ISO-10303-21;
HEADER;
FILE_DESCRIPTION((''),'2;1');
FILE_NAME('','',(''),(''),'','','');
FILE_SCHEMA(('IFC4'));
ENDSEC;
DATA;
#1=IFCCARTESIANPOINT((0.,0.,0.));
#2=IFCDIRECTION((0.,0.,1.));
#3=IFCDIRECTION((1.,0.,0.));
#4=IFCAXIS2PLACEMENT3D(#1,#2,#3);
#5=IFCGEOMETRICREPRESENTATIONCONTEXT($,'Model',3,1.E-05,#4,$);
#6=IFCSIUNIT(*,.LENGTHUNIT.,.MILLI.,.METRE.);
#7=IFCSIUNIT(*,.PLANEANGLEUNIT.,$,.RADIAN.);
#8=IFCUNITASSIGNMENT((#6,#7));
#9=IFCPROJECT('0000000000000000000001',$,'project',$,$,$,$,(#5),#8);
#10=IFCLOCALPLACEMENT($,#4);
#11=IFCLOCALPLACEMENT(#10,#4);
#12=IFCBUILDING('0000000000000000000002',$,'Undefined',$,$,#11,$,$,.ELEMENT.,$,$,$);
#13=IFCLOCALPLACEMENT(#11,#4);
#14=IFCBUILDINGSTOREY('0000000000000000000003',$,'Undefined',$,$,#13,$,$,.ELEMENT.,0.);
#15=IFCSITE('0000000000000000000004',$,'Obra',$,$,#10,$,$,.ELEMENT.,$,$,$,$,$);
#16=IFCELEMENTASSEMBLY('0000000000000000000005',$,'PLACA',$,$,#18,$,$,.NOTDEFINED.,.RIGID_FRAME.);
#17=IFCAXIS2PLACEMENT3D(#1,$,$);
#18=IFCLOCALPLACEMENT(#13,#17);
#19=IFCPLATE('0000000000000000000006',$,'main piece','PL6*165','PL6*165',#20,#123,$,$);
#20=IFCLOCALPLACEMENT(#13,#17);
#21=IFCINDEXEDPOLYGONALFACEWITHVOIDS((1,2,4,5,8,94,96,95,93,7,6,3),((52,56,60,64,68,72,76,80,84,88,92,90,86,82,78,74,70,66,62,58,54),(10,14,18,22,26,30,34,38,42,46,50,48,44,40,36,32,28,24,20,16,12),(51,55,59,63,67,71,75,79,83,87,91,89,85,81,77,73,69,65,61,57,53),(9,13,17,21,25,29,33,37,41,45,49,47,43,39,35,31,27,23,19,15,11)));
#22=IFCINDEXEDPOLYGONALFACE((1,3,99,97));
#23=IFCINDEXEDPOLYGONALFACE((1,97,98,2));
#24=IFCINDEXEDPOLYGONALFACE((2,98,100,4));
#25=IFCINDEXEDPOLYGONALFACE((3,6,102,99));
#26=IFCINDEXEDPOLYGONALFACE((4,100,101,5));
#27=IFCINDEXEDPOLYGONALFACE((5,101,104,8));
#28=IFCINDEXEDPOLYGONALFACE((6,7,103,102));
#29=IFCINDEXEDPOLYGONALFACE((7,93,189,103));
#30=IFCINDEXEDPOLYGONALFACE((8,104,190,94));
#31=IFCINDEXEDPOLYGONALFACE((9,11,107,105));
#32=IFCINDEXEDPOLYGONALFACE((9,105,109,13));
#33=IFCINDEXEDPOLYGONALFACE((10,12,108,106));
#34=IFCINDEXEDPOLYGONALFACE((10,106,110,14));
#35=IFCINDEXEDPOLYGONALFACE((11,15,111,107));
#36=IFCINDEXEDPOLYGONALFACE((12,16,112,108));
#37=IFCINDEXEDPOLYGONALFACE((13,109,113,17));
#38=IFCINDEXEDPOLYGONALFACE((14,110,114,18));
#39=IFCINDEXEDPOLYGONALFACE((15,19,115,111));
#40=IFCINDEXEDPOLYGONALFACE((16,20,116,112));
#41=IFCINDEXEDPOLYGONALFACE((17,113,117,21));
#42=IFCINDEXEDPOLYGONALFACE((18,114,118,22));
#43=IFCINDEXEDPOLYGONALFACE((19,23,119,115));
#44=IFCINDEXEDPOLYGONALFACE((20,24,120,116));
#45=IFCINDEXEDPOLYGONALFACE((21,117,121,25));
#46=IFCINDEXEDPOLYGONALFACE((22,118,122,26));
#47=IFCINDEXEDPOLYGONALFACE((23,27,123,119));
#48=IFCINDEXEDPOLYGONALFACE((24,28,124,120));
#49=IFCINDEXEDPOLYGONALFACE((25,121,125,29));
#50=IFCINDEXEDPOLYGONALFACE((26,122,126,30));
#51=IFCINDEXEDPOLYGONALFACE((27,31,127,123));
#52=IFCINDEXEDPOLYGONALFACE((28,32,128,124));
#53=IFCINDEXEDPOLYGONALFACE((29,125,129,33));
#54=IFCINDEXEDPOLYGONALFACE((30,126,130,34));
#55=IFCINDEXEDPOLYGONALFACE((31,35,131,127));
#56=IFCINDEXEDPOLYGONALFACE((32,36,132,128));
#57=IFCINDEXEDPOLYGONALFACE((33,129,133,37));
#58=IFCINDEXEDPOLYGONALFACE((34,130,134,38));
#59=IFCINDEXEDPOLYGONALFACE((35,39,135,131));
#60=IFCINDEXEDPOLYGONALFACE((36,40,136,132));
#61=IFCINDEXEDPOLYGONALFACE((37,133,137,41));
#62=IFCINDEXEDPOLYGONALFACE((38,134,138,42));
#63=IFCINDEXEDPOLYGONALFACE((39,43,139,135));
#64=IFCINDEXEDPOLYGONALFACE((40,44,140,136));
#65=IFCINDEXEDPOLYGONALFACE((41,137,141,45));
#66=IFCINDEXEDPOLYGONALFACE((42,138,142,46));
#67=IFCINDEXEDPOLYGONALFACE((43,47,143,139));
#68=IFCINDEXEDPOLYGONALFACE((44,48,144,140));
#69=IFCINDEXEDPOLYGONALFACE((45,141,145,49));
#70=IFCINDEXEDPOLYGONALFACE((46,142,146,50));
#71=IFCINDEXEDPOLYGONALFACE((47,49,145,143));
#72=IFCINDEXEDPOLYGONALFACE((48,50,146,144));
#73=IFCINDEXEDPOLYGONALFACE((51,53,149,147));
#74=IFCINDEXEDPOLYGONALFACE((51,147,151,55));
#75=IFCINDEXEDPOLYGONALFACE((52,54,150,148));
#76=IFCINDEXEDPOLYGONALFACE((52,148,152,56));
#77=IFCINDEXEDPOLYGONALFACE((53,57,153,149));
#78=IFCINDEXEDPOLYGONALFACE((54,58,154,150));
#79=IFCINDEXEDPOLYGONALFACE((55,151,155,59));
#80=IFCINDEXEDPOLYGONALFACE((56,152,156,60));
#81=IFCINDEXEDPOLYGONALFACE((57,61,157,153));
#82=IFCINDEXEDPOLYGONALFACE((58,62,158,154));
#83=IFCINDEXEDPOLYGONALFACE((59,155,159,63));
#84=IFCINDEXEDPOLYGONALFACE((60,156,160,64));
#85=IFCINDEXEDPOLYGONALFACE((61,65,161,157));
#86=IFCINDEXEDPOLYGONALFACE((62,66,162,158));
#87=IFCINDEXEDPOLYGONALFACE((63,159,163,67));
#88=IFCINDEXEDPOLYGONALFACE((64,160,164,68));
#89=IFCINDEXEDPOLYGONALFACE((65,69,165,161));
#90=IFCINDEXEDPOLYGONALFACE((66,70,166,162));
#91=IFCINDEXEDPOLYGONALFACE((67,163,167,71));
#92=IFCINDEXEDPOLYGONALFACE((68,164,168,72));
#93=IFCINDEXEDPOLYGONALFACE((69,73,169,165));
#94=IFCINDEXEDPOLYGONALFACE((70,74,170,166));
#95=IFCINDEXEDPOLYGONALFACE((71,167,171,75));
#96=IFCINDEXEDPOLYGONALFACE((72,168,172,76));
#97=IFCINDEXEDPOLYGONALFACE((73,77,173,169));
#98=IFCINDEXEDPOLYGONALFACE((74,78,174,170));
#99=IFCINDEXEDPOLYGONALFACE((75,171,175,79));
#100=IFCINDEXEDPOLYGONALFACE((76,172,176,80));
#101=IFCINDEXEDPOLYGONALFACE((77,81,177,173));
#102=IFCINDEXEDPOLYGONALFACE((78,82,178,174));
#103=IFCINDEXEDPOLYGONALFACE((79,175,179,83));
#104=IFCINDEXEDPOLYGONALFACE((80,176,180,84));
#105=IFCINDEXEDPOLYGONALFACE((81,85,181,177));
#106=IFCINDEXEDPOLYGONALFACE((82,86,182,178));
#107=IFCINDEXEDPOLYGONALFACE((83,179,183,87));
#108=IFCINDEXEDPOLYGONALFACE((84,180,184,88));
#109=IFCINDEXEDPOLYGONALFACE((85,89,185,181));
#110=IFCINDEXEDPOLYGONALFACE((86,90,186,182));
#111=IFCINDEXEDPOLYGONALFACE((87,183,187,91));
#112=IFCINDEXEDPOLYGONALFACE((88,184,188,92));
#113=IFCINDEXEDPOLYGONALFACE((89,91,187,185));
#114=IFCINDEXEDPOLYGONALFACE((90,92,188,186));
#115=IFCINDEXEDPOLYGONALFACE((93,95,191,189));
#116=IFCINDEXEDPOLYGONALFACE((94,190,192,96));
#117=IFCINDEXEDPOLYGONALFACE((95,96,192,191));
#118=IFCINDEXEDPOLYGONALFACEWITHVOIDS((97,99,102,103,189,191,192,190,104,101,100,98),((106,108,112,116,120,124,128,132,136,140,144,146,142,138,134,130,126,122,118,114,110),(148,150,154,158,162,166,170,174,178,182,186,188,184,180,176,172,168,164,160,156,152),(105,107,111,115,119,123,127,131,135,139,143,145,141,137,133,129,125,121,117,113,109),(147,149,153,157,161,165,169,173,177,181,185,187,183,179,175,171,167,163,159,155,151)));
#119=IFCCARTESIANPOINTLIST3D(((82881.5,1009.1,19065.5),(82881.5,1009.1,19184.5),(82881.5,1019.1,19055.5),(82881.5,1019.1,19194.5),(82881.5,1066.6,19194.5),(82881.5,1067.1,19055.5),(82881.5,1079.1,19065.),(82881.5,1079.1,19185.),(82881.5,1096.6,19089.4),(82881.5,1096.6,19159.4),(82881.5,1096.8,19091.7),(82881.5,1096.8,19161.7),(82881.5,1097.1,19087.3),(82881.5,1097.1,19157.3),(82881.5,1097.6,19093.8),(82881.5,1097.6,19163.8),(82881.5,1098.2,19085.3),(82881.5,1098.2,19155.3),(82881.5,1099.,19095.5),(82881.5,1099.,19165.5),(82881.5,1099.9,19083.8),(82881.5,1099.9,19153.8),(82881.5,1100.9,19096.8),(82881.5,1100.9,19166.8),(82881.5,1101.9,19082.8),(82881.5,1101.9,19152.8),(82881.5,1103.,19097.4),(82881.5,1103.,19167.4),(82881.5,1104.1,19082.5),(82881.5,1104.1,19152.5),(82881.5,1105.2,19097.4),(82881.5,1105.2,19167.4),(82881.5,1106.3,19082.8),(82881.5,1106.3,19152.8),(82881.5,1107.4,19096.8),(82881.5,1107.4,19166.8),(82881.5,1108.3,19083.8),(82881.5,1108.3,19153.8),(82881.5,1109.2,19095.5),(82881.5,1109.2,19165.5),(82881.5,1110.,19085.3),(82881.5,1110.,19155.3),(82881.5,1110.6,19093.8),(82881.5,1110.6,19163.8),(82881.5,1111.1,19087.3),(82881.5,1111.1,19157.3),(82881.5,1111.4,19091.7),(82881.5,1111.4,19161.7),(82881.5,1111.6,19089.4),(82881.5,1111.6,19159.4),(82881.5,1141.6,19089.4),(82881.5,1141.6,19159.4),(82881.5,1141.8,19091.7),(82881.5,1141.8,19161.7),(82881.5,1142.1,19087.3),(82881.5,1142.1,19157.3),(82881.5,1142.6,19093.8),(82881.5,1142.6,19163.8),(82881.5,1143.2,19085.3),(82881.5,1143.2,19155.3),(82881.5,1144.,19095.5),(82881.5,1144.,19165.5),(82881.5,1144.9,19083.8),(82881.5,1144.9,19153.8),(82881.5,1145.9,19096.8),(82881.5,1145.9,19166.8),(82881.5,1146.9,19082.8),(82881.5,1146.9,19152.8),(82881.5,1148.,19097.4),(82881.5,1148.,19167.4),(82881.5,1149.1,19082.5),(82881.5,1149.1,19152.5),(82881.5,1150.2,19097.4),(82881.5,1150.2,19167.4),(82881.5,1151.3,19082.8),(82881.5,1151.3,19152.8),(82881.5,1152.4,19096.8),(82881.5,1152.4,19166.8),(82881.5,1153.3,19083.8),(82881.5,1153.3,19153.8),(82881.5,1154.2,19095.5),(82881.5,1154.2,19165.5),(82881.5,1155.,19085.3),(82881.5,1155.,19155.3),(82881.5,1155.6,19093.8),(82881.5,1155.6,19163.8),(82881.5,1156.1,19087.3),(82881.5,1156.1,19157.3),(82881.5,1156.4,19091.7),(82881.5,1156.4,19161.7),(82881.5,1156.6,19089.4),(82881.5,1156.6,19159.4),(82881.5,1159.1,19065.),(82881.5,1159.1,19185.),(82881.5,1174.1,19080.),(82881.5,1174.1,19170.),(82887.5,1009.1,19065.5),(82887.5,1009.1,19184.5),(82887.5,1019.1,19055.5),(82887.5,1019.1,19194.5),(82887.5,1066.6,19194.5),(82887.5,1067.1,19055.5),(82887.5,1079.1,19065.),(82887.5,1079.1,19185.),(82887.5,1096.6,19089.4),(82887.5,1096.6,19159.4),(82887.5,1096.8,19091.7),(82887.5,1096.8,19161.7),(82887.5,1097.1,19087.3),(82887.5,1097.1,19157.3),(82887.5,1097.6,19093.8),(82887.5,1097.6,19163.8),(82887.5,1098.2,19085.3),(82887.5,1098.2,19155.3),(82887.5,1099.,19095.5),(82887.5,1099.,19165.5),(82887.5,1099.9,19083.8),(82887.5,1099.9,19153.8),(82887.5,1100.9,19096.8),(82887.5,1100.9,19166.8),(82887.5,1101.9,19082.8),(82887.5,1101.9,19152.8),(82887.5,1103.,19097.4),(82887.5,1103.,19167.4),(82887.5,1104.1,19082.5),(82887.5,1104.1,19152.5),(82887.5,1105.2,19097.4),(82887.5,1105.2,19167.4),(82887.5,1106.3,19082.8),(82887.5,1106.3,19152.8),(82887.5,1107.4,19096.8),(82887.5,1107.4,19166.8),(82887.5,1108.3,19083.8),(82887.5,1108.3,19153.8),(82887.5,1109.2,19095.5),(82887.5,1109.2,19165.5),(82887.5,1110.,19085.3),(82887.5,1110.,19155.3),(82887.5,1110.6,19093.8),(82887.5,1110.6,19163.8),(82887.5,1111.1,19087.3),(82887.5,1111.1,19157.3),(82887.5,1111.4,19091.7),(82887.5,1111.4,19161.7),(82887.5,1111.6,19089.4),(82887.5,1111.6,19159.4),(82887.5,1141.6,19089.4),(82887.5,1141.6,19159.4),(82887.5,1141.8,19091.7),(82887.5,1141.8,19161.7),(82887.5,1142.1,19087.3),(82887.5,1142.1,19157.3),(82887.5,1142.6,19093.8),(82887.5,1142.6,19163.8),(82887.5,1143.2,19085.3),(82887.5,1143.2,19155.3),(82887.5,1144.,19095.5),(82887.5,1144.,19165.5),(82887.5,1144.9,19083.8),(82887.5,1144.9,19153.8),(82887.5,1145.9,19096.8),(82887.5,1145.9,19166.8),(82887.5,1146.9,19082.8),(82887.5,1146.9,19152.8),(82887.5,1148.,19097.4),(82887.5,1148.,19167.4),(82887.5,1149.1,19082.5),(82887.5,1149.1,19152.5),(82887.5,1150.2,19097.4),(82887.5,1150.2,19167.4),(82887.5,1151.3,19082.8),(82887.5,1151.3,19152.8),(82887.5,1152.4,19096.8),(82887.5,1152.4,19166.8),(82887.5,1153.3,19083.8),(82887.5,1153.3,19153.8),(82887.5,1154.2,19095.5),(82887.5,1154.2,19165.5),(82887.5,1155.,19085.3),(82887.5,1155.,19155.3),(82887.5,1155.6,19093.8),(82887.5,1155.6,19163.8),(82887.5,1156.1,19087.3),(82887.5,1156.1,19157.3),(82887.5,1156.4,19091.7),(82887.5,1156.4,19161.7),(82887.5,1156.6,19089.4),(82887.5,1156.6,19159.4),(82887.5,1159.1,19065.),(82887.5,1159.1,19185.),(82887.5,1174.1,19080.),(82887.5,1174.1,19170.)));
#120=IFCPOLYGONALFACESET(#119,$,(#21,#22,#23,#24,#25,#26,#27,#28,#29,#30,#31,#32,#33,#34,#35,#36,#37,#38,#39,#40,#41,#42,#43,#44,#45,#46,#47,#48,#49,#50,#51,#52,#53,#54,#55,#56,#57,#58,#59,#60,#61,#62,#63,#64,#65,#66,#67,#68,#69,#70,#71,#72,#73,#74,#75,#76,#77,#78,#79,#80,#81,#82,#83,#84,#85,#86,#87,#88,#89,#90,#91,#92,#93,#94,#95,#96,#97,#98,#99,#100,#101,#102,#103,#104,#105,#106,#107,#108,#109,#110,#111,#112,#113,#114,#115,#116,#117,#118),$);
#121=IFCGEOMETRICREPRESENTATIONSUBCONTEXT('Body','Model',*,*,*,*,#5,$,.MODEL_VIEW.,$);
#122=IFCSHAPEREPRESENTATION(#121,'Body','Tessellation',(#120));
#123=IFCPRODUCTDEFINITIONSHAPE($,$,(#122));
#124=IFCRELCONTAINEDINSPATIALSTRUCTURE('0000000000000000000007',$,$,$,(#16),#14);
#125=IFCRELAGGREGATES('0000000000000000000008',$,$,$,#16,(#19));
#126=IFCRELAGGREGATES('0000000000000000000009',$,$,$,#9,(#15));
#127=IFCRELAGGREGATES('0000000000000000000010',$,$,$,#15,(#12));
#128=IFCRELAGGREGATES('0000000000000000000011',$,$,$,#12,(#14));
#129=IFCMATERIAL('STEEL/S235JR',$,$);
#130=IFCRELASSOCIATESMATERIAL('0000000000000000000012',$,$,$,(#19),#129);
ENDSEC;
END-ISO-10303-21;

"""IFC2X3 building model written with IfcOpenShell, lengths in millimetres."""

from ifc_helpers import new_model, si_unit, frame, origin_with_axes, origin_2d_with_axis, place, context, subcontext, project, spatial, polyline, circle, outline, extrude, source, transform, mapped, material, element, aggregate, save


model = new_model("IFC2X3")

# Units and contexts
model_context = context("Model", 3, precision=1e-05, world=origin_with_axes())
body_context = subcontext(model_context, "Body", "Model", "MODEL_VIEW")
ifc_project = project(units=[si_unit("LENGTHUNIT", "METRE", prefix="MILLI"), si_unit("PLANEANGLEUNIT", "RADIAN")], contexts=[model_context])

# Site, building, storey
site_placement = place(None, origin_with_axes())
site = spatial("IfcSite", under=ifc_project, at=site_placement, Name="Obra", CompositionType="ELEMENT")
building_placement = place(site_placement, origin_with_axes())
building = spatial("IfcBuilding", under=site, at=building_placement, Name="Undefined", CompositionType="ELEMENT")
storey_placement = place(building_placement, origin_with_axes())
storey = spatial("IfcBuildingStorey", under=building, at=storey_placement, Name="Undefined", CompositionType="ELEMENT", Elevation=0.0)

# Shared definitions
ifc_material_1 = material(Name="STEEL/S235JR")

# Element assembly, plate, opening
shared_shape_1 = source(origin_with_axes(), body_context, "Body", "SweptSolid", [
    extrude(circle(Radius=7.5, at=origin_2d_with_axis()), frame((0.0, 2.4, 0.0), z_axis=(0.0, 1.0, 0.0), x_axis=(1.0, 0.0, 0.0)), (0.0, 0.0, 1.0), 6.2),
])
assembly_1_placement = place(storey_placement, origin_with_axes())
assembly_1 = element("IfcElementAssembly", 1, at=assembly_1_placement, inside=storey, Name="PLACA", AssemblyPlace="NOTDEFINED", PredefinedType="RIGID_FRAME")
plate_1_placement = place(assembly_1_placement, frame((82884.5, 1009.1, 19065.5), z_axis=(1.0, 0.0, 0.0), x_axis=(0.0, 0.707107, -0.707107)))
plate_1 = element("IfcPlate", 2, at=plate_1_placement, material=ifc_material_1, Name="main piece", Description="PL6*165", ObjectType="PL6*165", context=body_context, shape_type="SweptSolid", body=[
    extrude(outline(polyline([(0.0, 0.0), (14.1, 0.0), (48.1, 33.9), (49.9, 49.1), (106.4, 105.7), (106.4, 126.9), (42.8, 190.6), (21.6, 190.6), (-35.0, 134.0), (-50.6, 131.9), (-84.1, 98.3), (-84.1, 84.1), (0.0, 0.0)])), frame((0.0, 0.0, -3.0), z_axis=(0.0, 0.0, 1.0), x_axis=(1.0, 0.0, 0.0)), (0.0, 0.0, 1.0), 6.0),
])
opening_1_placement = place(assembly_1_placement, frame((82890.0, 1126.6, 19160.0), z_axis=(0.0, 1.0, 0.0), x_axis=(0.0, 0.0, -1.0)))
element("IfcOpeningElement", 3, at=opening_1_placement, cuts=plate_1, ObjectType="Opening", context=body_context, shape_type="MappedRepresentation", body=[
    mapped(shared_shape_1, transform((0.0, 0.0, -22.5))),
    mapped(shared_shape_1, transform((70.0, 0.0, -22.5))),
    mapped(shared_shape_1, transform((0.0, 0.0, 22.5))),
    mapped(shared_shape_1, transform((70.0, 0.0, 22.5))),
])
aggregate(assembly_1, [plate_1])

save(model, "model.ifc")
